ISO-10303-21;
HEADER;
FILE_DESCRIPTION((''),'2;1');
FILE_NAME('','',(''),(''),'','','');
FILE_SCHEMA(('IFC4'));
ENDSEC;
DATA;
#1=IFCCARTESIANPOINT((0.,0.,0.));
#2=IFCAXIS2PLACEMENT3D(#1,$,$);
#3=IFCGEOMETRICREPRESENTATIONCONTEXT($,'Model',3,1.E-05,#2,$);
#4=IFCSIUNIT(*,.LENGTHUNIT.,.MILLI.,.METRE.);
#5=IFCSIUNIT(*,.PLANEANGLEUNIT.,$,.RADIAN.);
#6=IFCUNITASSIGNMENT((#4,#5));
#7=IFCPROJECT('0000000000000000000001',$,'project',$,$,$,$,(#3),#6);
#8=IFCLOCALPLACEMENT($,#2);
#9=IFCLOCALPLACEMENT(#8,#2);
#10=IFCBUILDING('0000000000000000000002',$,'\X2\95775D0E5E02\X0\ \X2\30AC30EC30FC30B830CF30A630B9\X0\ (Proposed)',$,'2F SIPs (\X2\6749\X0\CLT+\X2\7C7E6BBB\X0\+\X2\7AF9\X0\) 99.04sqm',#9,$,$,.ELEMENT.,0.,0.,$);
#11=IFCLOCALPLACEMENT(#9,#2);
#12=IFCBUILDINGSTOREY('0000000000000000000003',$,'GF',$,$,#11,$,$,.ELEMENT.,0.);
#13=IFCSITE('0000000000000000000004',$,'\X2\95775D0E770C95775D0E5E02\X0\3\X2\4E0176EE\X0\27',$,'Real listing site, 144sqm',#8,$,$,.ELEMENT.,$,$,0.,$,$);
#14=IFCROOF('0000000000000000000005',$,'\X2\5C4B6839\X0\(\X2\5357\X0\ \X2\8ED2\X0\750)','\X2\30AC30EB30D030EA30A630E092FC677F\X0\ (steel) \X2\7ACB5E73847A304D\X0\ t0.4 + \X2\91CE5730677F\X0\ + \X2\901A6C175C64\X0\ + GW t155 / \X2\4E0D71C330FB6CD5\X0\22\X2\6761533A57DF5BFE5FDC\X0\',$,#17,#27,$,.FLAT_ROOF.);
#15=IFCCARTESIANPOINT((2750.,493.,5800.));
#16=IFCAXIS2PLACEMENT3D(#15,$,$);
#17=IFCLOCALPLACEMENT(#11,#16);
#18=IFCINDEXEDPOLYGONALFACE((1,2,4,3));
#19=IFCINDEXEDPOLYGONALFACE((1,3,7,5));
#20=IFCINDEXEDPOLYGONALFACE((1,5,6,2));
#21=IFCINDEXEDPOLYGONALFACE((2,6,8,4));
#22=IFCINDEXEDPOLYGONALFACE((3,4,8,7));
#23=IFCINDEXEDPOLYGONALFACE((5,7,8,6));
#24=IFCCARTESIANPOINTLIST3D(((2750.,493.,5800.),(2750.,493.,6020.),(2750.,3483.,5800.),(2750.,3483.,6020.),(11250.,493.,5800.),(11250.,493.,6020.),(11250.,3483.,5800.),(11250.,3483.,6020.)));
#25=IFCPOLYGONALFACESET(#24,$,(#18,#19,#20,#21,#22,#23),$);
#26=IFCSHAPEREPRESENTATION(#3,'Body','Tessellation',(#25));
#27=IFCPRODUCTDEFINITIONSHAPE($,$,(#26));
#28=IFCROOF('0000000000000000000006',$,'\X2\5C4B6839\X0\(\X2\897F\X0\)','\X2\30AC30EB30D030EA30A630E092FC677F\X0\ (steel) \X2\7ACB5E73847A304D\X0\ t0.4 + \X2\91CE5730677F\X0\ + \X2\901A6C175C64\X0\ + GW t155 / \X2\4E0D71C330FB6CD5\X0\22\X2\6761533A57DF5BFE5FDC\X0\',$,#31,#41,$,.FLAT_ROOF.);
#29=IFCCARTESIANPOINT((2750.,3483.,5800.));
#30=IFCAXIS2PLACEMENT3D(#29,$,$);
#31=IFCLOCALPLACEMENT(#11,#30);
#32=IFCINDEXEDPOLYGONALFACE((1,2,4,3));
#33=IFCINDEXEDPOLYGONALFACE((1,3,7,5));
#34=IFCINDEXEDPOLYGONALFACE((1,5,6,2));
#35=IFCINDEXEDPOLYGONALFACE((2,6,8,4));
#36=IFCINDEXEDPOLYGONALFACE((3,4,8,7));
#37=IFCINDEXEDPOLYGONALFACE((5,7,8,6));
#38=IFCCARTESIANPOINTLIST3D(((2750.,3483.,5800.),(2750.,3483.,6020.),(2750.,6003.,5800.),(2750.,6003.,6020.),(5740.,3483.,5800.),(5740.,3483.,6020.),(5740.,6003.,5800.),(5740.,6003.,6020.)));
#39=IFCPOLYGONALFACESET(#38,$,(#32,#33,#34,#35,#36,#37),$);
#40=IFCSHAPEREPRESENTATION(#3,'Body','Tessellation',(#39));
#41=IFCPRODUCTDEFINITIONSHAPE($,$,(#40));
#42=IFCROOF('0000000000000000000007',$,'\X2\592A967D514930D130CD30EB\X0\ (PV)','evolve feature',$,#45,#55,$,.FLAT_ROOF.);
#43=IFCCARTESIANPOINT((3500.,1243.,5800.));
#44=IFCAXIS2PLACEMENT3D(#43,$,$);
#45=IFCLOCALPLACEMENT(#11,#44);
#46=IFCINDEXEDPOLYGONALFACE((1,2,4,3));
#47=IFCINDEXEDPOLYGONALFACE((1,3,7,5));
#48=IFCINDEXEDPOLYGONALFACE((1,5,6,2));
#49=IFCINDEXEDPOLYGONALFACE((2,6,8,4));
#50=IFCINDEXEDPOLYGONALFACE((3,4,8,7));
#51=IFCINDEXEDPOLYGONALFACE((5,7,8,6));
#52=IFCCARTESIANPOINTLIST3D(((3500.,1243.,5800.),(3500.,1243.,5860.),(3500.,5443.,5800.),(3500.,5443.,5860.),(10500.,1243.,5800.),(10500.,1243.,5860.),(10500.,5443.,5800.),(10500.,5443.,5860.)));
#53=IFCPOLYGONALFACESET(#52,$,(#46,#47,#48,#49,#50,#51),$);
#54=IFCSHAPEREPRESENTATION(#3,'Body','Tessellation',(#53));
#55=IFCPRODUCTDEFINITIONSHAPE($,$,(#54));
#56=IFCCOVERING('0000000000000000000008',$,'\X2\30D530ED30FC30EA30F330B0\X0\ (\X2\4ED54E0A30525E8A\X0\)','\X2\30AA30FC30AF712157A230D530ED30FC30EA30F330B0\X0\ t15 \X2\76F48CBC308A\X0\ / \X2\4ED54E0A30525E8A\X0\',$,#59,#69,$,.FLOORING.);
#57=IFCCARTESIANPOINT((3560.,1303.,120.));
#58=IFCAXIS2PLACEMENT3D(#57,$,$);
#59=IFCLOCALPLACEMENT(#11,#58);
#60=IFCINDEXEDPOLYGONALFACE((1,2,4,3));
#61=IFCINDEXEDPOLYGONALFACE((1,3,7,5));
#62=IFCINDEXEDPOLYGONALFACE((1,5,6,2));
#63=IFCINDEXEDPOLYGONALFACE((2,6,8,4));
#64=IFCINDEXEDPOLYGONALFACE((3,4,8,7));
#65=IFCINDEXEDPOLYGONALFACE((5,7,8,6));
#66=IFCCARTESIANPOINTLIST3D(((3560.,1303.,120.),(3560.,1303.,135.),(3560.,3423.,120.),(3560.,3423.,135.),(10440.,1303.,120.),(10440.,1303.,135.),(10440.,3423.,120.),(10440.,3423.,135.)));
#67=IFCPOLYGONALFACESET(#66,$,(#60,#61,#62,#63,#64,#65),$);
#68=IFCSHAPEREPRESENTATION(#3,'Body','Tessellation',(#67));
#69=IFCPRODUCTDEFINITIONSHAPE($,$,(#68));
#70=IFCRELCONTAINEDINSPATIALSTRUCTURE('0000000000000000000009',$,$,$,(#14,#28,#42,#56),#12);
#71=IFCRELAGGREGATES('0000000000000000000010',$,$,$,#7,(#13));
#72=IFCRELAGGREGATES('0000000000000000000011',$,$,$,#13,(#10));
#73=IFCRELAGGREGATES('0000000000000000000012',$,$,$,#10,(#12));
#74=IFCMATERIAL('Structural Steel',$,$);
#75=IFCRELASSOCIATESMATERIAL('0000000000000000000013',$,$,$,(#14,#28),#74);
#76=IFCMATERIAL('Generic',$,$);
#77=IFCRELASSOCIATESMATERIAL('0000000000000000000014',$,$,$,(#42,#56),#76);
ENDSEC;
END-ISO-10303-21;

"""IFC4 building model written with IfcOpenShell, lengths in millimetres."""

from ifc_helpers import new_model, si_unit, frame, frame_2d, origin, place, context, project, spatial, rectangle, extrude, material, element, save


model = new_model("IFC4")

# Units and contexts
model_context = context("Model", 3, precision=1e-05, world=origin())
ifc_project = project(units=[si_unit("LENGTHUNIT", "METRE", prefix="MILLI"), si_unit("PLANEANGLEUNIT", "RADIAN")], contexts=[model_context])

# Site, building, storey
site_placement = place(None, origin())
site = spatial("IfcSite", under=ifc_project, at=site_placement, Name="長崎県長崎市3丁目27", ObjectType="Real listing site, 144sqm", CompositionType="ELEMENT", RefElevation=0.0)
building_placement = place(site_placement, origin())
building = spatial("IfcBuilding", under=site, at=building_placement, Name="長崎市 ガレージハウス (Proposed)", ObjectType="2F SIPs (杉CLT+籾殻+竹) 99.04sqm", CompositionType="ELEMENT", ElevationOfRefHeight=0.0, ElevationOfTerrain=0.0)
storey_placement = place(building_placement, origin())
storey = spatial("IfcBuildingStorey", under=building, at=storey_placement, Name="GF", CompositionType="ELEMENT", Elevation=0.0)

# Shared definitions
ifc_material_1 = material(Name="Generic")

# Roofs
ifc_material_2 = material(Name="Structural Steel")
roof_1_placement = place(storey_placement, frame((2750.0, 493.0, 5800.0)))
element("IfcRoof", 1, at=roof_1_placement, inside=storey, material=ifc_material_2, Name="屋根(南 軒750)", Description="ガルバリウム鋼板 (steel) 立平葺き t0.4 + 野地板 + 通気層 + GW t155 / 不燃・法22条区域対応", PredefinedType="FLAT_ROOF", context=model_context, shape_type="SweptSolid", body=[
    extrude(rectangle(XDim=8500.0, YDim=2990.0, at=frame_2d((4250.0, 1495.0))), frame((2750.0, 493.0, 5800.0)), (0.0, 0.0, 1.0), 220.0),
])
roof_2_placement = place(storey_placement, frame((2750.0, 3483.0, 5800.0)))
element("IfcRoof", 2, at=roof_2_placement, inside=storey, material=ifc_material_2, Name="屋根(西)", Description="ガルバリウム鋼板 (steel) 立平葺き t0.4 + 野地板 + 通気層 + GW t155 / 不燃・法22条区域対応", PredefinedType="FLAT_ROOF", context=model_context, shape_type="SweptSolid", body=[
    extrude(rectangle(XDim=2990.0, YDim=2520.0, at=frame_2d((1495.0, 1260.0))), frame((2750.0, 3483.0, 5800.0)), (0.0, 0.0, 1.0), 220.0),
])
roof_3_placement = place(storey_placement, frame((3500.0, 1243.0, 5800.0)))
element("IfcRoof", 3, at=roof_3_placement, inside=storey, material=ifc_material_1, Name="太陽光パネル (PV)", Description="evolve feature", PredefinedType="FLAT_ROOF", context=model_context, shape_type="SweptSolid", body=[
    extrude(rectangle(XDim=7000.0, YDim=4200.0, at=frame_2d((3500.0, 2100.0))), frame((3500.0, 1243.0, 5800.0)), (0.0, 0.0, 1.0), 60.0),
])

# Covering
covering_placement = place(storey_placement, frame((3560.0, 1303.0, 120.0)))
element("IfcCovering", 4, at=covering_placement, inside=storey, material=ifc_material_1, Name="フローリング (仕上げ床)", Description="オーク無垢フローリング t15 直貼り / 仕上げ床", PredefinedType="FLOORING", context=model_context, shape_type="SweptSolid", body=[
    extrude(rectangle(XDim=6880.0, YDim=2120.0, at=frame_2d((3440.0, 1060.0))), frame((3560.0, 1303.0, 120.0)), (0.0, 0.0, 1.0), 15.0),
])

save(model, "model.ifc")
